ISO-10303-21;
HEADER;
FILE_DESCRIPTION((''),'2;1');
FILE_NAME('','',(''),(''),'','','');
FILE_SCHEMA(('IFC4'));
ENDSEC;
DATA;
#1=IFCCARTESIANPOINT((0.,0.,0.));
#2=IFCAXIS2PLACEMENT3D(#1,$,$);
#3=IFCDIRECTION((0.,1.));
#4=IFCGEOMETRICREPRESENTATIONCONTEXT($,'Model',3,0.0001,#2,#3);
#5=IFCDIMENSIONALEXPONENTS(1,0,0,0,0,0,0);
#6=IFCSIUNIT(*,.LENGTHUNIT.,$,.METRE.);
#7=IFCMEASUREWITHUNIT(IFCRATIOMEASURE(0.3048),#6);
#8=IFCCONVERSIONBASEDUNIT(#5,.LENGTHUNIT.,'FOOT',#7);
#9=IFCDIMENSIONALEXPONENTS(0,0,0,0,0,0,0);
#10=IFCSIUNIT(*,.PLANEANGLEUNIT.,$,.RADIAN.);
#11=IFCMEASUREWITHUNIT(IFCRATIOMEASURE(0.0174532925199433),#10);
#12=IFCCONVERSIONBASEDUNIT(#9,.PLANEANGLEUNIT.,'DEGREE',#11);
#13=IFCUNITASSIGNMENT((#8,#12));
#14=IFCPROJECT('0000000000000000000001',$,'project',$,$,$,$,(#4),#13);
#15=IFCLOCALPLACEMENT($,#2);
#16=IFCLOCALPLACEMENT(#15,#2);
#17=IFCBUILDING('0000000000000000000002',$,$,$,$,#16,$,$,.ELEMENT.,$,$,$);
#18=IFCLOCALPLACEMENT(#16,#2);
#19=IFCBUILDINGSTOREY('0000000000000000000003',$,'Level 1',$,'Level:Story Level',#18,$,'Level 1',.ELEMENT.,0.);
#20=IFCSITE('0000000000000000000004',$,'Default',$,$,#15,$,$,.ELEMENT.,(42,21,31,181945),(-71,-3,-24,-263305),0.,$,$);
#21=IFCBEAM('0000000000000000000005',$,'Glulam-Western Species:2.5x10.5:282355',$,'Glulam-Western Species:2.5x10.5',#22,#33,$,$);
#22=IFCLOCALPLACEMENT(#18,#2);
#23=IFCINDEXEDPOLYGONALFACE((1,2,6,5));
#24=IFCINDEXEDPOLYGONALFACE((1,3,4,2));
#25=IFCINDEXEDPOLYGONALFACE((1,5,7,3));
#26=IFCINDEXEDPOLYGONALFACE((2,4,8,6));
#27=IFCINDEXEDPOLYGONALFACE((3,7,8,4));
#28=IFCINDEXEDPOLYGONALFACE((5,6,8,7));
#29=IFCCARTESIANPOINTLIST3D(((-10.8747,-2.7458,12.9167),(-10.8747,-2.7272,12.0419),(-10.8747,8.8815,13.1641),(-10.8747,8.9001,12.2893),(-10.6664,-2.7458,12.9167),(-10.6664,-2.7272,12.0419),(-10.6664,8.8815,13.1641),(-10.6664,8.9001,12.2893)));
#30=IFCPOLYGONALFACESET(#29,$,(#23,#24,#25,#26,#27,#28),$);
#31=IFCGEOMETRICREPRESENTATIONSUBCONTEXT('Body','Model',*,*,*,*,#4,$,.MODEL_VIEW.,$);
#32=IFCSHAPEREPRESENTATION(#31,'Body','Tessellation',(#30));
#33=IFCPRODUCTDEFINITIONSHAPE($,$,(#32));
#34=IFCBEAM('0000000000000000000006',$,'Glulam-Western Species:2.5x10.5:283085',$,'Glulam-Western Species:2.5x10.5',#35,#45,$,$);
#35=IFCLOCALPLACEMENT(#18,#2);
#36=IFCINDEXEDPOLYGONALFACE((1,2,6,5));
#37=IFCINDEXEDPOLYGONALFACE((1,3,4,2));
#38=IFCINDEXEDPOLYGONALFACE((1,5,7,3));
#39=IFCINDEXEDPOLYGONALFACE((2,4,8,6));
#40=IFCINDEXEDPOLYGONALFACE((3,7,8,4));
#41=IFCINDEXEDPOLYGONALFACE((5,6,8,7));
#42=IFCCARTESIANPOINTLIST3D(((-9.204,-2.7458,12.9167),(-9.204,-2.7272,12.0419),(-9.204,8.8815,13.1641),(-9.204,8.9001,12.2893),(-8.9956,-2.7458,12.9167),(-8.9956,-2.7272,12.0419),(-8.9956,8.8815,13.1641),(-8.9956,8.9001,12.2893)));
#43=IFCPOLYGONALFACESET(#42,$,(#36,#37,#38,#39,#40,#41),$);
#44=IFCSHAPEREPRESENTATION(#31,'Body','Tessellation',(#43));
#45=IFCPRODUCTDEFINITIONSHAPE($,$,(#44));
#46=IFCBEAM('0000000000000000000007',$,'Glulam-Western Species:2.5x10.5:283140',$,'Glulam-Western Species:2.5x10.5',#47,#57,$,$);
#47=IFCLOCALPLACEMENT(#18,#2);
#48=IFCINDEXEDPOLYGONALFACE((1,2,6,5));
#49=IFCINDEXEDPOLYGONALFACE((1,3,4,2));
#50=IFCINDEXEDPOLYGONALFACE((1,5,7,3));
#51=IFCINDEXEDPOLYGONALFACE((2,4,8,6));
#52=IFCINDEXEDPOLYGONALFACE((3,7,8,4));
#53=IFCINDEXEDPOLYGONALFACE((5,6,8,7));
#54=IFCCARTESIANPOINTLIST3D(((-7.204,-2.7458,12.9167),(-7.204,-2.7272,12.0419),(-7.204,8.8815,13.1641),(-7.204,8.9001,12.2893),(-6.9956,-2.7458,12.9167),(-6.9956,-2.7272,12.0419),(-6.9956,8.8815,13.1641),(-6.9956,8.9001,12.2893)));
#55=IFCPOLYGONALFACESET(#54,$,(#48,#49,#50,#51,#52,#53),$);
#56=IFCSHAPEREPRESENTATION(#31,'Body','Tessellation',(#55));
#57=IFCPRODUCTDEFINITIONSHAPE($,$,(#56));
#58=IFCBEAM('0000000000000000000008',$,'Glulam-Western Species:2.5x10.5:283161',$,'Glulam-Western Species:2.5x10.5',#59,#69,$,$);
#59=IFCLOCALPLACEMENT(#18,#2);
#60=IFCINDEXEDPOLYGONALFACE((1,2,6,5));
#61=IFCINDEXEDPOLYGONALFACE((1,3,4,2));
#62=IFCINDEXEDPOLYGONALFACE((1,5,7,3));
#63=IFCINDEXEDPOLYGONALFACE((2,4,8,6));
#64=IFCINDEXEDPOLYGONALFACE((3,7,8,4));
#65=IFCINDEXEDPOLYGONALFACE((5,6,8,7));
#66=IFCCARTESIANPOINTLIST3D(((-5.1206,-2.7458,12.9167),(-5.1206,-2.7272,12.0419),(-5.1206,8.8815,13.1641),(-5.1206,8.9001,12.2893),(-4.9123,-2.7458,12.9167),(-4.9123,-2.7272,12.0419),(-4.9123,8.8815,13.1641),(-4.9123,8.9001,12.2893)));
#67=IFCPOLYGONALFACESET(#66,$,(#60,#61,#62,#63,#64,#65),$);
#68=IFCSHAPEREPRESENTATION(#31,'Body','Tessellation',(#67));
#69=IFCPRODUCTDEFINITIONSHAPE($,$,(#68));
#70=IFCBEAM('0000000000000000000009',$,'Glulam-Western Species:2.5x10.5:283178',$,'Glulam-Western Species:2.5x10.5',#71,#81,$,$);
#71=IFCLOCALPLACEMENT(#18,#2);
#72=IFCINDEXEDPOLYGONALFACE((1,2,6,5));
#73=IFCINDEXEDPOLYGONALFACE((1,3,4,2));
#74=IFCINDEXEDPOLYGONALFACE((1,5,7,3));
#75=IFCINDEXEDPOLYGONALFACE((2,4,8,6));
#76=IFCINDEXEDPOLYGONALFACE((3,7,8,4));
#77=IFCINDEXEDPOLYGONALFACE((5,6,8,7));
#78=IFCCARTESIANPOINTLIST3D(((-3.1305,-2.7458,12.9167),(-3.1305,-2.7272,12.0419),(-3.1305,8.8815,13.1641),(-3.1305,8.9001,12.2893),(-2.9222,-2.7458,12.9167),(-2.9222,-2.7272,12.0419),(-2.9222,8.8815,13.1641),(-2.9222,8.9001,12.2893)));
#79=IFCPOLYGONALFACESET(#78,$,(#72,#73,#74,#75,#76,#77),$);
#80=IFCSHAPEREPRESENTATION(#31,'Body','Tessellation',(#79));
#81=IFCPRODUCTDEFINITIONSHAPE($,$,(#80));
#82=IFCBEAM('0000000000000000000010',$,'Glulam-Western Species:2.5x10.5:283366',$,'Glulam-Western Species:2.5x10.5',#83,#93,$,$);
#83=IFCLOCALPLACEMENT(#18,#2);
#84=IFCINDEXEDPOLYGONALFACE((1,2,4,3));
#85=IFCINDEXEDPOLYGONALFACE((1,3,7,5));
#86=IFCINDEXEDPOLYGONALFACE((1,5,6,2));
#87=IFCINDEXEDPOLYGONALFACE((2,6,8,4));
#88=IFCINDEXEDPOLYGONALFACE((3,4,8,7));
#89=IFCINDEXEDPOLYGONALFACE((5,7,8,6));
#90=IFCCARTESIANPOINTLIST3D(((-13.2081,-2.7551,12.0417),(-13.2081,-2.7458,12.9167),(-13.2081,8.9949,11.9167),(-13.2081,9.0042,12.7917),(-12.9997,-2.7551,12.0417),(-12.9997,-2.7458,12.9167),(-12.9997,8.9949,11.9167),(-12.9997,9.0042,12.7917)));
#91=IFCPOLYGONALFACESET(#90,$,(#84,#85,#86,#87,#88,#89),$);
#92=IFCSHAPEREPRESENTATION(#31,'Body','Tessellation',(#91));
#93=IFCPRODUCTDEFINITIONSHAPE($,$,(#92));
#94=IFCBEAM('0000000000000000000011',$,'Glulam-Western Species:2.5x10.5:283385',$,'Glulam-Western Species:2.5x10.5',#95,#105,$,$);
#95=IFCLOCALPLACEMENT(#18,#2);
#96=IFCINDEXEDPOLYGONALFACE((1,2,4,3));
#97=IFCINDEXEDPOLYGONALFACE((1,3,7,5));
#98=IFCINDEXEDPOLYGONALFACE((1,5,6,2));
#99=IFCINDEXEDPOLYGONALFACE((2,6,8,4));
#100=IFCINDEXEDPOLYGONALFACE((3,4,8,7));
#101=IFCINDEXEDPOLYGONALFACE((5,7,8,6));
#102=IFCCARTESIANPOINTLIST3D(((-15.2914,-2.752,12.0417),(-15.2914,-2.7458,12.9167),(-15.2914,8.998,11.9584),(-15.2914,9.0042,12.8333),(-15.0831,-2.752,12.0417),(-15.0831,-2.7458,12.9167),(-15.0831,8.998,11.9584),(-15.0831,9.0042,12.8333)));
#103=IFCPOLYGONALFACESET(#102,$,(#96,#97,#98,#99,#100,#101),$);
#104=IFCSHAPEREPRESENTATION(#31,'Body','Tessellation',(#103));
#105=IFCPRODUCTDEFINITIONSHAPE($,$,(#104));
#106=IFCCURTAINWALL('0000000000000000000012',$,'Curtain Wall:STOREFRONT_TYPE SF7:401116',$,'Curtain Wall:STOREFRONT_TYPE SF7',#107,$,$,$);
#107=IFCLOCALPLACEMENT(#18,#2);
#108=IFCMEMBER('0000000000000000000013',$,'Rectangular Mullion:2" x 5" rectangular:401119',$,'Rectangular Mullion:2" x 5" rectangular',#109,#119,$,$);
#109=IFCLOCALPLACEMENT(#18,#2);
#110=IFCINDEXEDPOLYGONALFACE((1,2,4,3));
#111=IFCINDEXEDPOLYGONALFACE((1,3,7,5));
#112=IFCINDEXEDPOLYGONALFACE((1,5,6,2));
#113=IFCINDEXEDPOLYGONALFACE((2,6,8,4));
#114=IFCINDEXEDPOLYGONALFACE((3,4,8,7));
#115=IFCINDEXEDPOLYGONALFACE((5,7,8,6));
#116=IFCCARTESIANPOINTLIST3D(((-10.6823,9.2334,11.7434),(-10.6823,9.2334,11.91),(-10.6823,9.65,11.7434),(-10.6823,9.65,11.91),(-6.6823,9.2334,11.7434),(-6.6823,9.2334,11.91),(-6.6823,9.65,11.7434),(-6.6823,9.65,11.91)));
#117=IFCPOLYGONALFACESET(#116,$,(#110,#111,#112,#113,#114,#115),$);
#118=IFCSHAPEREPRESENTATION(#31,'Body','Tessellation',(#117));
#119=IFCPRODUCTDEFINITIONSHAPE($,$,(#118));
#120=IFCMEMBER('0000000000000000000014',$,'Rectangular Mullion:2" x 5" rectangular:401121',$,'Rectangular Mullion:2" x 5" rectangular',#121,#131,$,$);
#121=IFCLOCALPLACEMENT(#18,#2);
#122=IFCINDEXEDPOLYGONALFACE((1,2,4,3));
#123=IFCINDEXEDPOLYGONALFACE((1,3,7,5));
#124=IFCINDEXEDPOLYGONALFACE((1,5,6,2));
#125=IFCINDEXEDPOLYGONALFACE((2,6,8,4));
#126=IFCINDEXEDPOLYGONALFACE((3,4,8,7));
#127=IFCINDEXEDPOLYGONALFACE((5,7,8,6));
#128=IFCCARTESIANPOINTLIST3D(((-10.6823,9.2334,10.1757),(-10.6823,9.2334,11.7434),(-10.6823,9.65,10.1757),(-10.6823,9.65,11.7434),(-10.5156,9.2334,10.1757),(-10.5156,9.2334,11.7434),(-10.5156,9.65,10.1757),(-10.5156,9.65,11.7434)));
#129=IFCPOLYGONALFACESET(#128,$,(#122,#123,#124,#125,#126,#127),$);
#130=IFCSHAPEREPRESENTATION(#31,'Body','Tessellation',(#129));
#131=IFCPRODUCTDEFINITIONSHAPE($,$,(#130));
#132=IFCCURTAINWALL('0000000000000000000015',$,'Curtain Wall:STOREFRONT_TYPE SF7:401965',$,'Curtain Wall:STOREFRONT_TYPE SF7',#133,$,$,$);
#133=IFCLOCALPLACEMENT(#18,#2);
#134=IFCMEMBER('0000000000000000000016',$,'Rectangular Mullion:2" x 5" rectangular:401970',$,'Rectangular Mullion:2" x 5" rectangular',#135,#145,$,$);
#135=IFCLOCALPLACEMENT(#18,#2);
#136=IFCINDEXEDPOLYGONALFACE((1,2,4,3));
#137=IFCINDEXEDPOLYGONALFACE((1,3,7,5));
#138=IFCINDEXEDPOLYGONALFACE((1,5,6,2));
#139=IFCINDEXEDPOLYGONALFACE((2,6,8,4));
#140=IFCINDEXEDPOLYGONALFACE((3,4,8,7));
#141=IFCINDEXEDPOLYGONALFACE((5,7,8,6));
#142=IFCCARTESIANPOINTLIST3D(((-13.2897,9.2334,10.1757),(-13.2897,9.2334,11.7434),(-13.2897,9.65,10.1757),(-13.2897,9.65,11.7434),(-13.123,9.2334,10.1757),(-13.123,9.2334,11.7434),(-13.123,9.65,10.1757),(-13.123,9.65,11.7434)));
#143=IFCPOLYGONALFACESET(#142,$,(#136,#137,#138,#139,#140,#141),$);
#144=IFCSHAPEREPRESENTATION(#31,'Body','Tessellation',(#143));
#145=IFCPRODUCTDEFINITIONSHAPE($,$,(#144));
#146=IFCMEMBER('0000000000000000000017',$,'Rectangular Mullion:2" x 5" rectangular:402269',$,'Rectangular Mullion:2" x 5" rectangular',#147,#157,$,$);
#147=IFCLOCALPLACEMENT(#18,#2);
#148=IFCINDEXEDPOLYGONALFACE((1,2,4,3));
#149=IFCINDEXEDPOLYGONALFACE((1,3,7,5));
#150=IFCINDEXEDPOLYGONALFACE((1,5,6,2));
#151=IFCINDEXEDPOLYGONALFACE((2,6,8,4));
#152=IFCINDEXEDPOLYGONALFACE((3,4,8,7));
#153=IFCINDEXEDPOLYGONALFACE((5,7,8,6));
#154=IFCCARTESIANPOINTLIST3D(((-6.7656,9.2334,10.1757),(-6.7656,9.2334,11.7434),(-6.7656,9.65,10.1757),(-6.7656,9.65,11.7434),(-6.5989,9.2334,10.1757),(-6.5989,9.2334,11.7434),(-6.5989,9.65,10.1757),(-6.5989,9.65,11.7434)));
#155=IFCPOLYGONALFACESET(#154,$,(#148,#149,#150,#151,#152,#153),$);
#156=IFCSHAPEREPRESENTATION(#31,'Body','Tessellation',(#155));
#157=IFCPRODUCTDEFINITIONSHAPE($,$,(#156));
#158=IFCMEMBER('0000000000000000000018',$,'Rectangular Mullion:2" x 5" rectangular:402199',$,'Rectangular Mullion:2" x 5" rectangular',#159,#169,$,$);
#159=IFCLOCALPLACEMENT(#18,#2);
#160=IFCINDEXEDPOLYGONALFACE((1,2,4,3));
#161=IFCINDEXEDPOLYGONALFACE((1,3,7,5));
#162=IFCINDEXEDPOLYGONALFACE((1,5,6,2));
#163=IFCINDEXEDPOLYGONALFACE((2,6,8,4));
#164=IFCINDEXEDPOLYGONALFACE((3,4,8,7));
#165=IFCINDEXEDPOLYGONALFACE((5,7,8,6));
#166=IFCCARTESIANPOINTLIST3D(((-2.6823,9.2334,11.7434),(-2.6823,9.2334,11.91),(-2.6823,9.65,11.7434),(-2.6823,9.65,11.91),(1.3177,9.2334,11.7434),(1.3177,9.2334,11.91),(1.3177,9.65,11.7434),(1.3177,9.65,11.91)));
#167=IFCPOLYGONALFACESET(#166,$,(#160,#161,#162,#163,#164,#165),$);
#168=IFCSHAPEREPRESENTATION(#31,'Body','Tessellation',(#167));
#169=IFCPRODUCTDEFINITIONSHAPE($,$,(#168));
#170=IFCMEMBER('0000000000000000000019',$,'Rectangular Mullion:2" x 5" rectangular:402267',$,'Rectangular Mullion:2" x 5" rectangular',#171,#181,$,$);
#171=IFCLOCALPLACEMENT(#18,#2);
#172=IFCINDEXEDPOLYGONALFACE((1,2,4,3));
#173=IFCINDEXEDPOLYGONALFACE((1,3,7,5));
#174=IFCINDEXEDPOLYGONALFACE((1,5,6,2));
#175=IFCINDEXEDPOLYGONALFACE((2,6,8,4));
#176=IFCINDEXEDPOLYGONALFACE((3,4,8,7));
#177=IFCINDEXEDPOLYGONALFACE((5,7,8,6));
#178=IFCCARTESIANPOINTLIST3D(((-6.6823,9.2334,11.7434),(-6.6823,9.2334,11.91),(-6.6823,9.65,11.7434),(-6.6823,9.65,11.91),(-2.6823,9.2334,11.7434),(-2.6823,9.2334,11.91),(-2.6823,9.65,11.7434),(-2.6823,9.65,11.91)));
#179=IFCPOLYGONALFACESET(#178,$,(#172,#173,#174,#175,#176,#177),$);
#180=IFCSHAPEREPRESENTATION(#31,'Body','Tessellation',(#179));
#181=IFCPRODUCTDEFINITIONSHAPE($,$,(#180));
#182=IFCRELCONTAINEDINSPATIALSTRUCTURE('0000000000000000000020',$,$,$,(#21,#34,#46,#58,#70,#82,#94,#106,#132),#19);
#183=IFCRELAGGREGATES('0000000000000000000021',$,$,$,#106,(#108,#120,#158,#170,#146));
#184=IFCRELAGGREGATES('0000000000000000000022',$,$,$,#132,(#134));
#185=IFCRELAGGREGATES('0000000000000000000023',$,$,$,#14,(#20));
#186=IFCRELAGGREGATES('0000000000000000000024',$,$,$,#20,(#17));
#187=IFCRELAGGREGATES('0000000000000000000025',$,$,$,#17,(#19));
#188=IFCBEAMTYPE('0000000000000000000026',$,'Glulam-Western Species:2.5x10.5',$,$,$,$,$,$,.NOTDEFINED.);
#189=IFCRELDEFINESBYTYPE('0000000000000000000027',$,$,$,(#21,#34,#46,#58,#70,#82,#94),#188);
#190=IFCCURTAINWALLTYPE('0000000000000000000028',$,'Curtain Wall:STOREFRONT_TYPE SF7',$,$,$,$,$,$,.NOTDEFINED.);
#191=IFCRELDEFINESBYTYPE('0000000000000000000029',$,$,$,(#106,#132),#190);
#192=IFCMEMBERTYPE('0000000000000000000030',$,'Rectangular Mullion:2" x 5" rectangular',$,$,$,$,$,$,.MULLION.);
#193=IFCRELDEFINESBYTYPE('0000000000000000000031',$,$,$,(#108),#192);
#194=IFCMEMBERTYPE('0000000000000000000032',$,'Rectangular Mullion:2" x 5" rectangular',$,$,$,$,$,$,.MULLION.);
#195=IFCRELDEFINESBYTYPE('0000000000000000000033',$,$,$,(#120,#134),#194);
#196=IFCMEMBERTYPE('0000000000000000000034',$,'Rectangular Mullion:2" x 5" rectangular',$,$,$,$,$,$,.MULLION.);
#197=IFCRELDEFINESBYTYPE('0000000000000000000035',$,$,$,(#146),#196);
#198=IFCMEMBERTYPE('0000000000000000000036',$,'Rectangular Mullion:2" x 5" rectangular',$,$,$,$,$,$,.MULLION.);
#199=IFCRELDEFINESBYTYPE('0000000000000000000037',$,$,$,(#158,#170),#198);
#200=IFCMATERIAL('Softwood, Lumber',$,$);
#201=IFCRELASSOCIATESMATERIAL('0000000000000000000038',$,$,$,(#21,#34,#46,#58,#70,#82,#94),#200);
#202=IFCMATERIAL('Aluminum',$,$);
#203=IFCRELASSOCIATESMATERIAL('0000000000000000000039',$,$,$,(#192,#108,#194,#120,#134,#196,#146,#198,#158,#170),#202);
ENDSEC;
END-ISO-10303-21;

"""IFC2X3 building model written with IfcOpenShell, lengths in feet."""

from ifc_helpers import new_model, entity, si_unit, converted_unit, direction, frame, frame_2d, origin, origin_2d_with_axis, place, context, subcontext, project, spatial, rectangle, extrude, source, transform, mapped, material, type_object, type_shapes, element, aggregate, save


model = new_model("IFC2X3")

# Units and contexts
model_context = context("Model", 3, precision=0.0001, world=origin(), true_north=direction((0.0, 1.0)))
body_context = subcontext(model_context, "Body", "Model", "MODEL_VIEW")
ifc_project = project(units=[converted_unit("LENGTHUNIT", "FOOT", entity("IfcRatioMeasure", 0.3048), si_unit("LENGTHUNIT", "METRE"), dimensions=[1, 0, 0, 0, 0, 0, 0]), converted_unit("PLANEANGLEUNIT", "DEGREE", entity("IfcRatioMeasure", 0.0174532925199433), si_unit("PLANEANGLEUNIT", "RADIAN"), dimensions=[0, 0, 0, 0, 0, 0, 0])], contexts=[model_context])

# Site, building, storey
site_placement = place(None, origin())
site = spatial("IfcSite", under=ifc_project, at=site_placement, Name="Default", CompositionType="ELEMENT", RefLatitude=(42, 21, 31, 181945), RefLongitude=(-71, -3, -24, -263305), RefElevation=0.0)
building_placement = place(site_placement, origin())
building = spatial("IfcBuilding", under=site, at=building_placement, CompositionType="ELEMENT")
storey_placement = place(building_placement, origin())
storey = spatial("IfcBuildingStorey", under=building, at=storey_placement, Name="Level 1", ObjectType="Level:Story Level", LongName="Level 1", CompositionType="ELEMENT", Elevation=0.0)

# Beams
ifc_material_1 = material(Name="Softwood, Lumber")
beam_type = type_object("IfcBeamType", Name="Glulam-Western Species:2.5x10.5", PredefinedType="NOTDEFINED")
beam_1_placement = place(storey_placement, frame((-10.7706, 9.0042, 13.1667), z_axis=(0.0, -0.021272, 0.999774), x_axis=(0.0, -0.999774, -0.021272)))
element("IfcBeam", 1, at=beam_1_placement, inside=storey, type_object=beam_type, material=ifc_material_1, Name="Glulam-Western Species:2.5x10.5:282355", ObjectType="Glulam-Western Species:2.5x10.5", context=body_context, shape_type="SweptSolid", body=[
    extrude(rectangle(XDim=0.875, YDim=0.2083, at=origin_2d_with_axis()), frame((0.1228, 0.0, -0.4375), z_axis=(1.0, 0.0, 0.0), x_axis=(0.0, 0.0, -1.0)), (0.0, 0.0, 1.0), 11.6299),
])
beam_2_placement = place(storey_placement, frame((-9.0998, 9.0042, 13.1667), z_axis=(0.0, -0.021272, 0.999774), x_axis=(0.0, -0.999774, -0.021272)))
element("IfcBeam", 2, at=beam_2_placement, inside=storey, type_object=beam_type, material=ifc_material_1, Name="Glulam-Western Species:2.5x10.5:283085", ObjectType="Glulam-Western Species:2.5x10.5", context=body_context, shape_type="SweptSolid", body=[
    extrude(rectangle(XDim=0.875, YDim=0.2083, at=origin_2d_with_axis()), frame((0.1228, 0.0, -0.4375), z_axis=(1.0, 0.0, 0.0), x_axis=(0.0, 0.0, -1.0)), (0.0, 0.0, 1.0), 11.6299),
])
beam_3_placement = place(storey_placement, frame((-7.0998, 9.0042, 13.1667), z_axis=(0.0, -0.021272, 0.999774), x_axis=(0.0, -0.999774, -0.021272)))
element("IfcBeam", 3, at=beam_3_placement, inside=storey, type_object=beam_type, material=ifc_material_1, Name="Glulam-Western Species:2.5x10.5:283140", ObjectType="Glulam-Western Species:2.5x10.5", context=body_context, shape_type="SweptSolid", body=[
    extrude(rectangle(XDim=0.875, YDim=0.2083, at=frame_2d((0.0, 0.0), x_axis=(1.0, 0.0))), frame((0.1228, 0.0, -0.4375), z_axis=(1.0, 0.0, 0.0), x_axis=(0.0, 0.0, -1.0)), (0.0, 0.0, 1.0), 11.6299),
])
beam_4_placement = place(storey_placement, frame((-5.0165, 9.0042, 13.1667), z_axis=(0.0, -0.021272, 0.999774), x_axis=(0.0, -0.999774, -0.021272)))
element("IfcBeam", 4, at=beam_4_placement, inside=storey, type_object=beam_type, material=ifc_material_1, Name="Glulam-Western Species:2.5x10.5:283161", ObjectType="Glulam-Western Species:2.5x10.5", context=body_context, shape_type="SweptSolid", body=[
    extrude(rectangle(XDim=0.875, YDim=0.2083, at=origin_2d_with_axis()), frame((0.1228, 0.0, -0.4375), z_axis=(1.0, 0.0, 0.0), x_axis=(0.0, 0.0, -1.0)), (0.0, 0.0, 1.0), 11.6299),
])
beam_5_placement = place(storey_placement, frame((-3.0263, 9.0042, 13.1667), z_axis=(0.0, -0.021272, 0.999774), x_axis=(0.0, -0.999774, -0.021272)))
element("IfcBeam", 5, at=beam_5_placement, inside=storey, type_object=beam_type, material=ifc_material_1, Name="Glulam-Western Species:2.5x10.5:283178", ObjectType="Glulam-Western Species:2.5x10.5", context=body_context, shape_type="SweptSolid", body=[
    extrude(rectangle(XDim=0.875, YDim=0.2083, at=frame_2d((0.0, 0.0), x_axis=(1.0, 0.0))), frame((0.1228, 0.0, -0.4375), z_axis=(1.0, 0.0, 0.0), x_axis=(0.0, 0.0, -1.0)), (0.0, 0.0, 1.0), 11.6299),
])
beam_6_placement = place(storey_placement, frame((-13.1039, 9.0042, 12.7917), z_axis=(0.0, 0.010638, 0.999943), x_axis=(0.0, -0.999943, 0.010638)))
element("IfcBeam", 6, at=beam_6_placement, inside=storey, type_object=beam_type, material=ifc_material_1, Name="Glulam-Western Species:2.5x10.5:283366", ObjectType="Glulam-Western Species:2.5x10.5", context=body_context, shape_type="SweptSolid", body=[
    extrude(rectangle(XDim=0.875, YDim=0.2083, at=frame_2d((0.0, 0.0), x_axis=(1.0, 0.0))), frame((0.0, 0.0, -0.4375), z_axis=(1.0, 0.0, 0.0), x_axis=(0.0, 0.0, -1.0)), (0.0, 0.0, 1.0), 11.7507),
])
beam_7_placement = place(storey_placement, frame((-15.1872, 9.0042, 12.8333), z_axis=(0.0, 0.007092, 0.999975), x_axis=(0.0, -0.999975, 0.007092)))
element("IfcBeam", 7, at=beam_7_placement, inside=storey, type_object=beam_type, material=ifc_material_1, Name="Glulam-Western Species:2.5x10.5:283385", ObjectType="Glulam-Western Species:2.5x10.5", context=body_context, shape_type="SweptSolid", body=[
    extrude(rectangle(XDim=0.875, YDim=0.2083, at=origin_2d_with_axis()), frame((0.0, 0.0, -0.4375), z_axis=(1.0, 0.0, 0.0), x_axis=(0.0, 0.0, -1.0)), (0.0, 0.0, 1.0), 11.7503),
])

# Curtain wall, members
curtain_wall_type = type_object("IfcCurtainWallType", Name="Curtain Wall:STOREFRONT_TYPE SF7", PredefinedType="NOTDEFINED")
curtain_wall_1_placement = place(storey_placement, origin())
curtain_wall_1 = element("IfcCurtainWall", 8, at=curtain_wall_1_placement, inside=storey, type_object=curtain_wall_type, Name="Curtain Wall:STOREFRONT_TYPE SF7:401116", ObjectType="Curtain Wall:STOREFRONT_TYPE SF7")
ifc_material_2 = material(Name="Aluminum")
member_type_1 = type_object("IfcMemberType", Name="Rectangular Mullion:2\" x 5\" rectangular", PredefinedType="MULLION", material=ifc_material_2)
shared_shape_1 = source(origin(), body_context, "Body", "SweptSolid", [
    extrude(rectangle(XDim=0.4167, YDim=0.1667, at=origin_2d_with_axis()), frame((-0.0833, 0.0, -4.0), z_axis=(0.0, 0.0, 1.0), x_axis=(0.0, -1.0, 0.0)), (0.0, 0.0, 1.0), 4.0),
])
type_shapes(member_type_1, [shared_shape_1])
member_1_placement = place(curtain_wall_1_placement, frame((-10.6823, 9.4417, 11.91), z_axis=(-1.0, 0.0, 0.0), x_axis=(0.0, 0.0, 1.0)))
member_1 = element("IfcMember", 9, at=member_1_placement, type_object=member_type_1, material=ifc_material_2, Name="Rectangular Mullion:2\" x 5\" rectangular:401119", ObjectType="Rectangular Mullion:2\" x 5\" rectangular", context=body_context, shape_type="MappedRepresentation", body=[
    mapped(shared_shape_1, transform((0.0, 0.0, 0.0), scale=1.0)),
])
member_type_2 = type_object("IfcMemberType", Name="Rectangular Mullion:2\" x 5\" rectangular", PredefinedType="MULLION", material=ifc_material_2)
shared_shape_2 = source(origin(), body_context, "Body", "SweptSolid", [
    extrude(rectangle(XDim=0.4167, YDim=0.1667, at=origin_2d_with_axis()), frame((-0.0833, 0.0, -1.5677), z_axis=(0.0, 0.0, 1.0), x_axis=(0.0, -1.0, 0.0)), (0.0, 0.0, 1.0), 1.5677),
])
type_shapes(member_type_2, [shared_shape_2])
member_2_placement = place(curtain_wall_1_placement, frame((-10.6823, 9.4417, 10.1757), z_axis=(0.0, 0.0, -1.0), x_axis=(-1.0, 0.0, 0.0)))
member_2 = element("IfcMember", 10, at=member_2_placement, type_object=member_type_2, material=ifc_material_2, Name="Rectangular Mullion:2\" x 5\" rectangular:401121", ObjectType="Rectangular Mullion:2\" x 5\" rectangular", context=body_context, shape_type="MappedRepresentation", body=[
    mapped(shared_shape_2, transform((0.0, 0.0, 0.0), scale=1.0)),
])

# Curtain wall, member
curtain_wall_2_placement = place(storey_placement, origin())
curtain_wall_2 = element("IfcCurtainWall", 11, at=curtain_wall_2_placement, inside=storey, type_object=curtain_wall_type, Name="Curtain Wall:STOREFRONT_TYPE SF7:401965", ObjectType="Curtain Wall:STOREFRONT_TYPE SF7")
member_3_placement = place(curtain_wall_2_placement, frame((-13.123, 9.4417, 10.1757), z_axis=(0.0, 0.0, -1.0), x_axis=(1.0, 0.0, 0.0)))
member_3 = element("IfcMember", 12, at=member_3_placement, type_object=member_type_2, material=ifc_material_2, Name="Rectangular Mullion:2\" x 5\" rectangular:401970", ObjectType="Rectangular Mullion:2\" x 5\" rectangular", context=body_context, shape_type="MappedRepresentation", body=[
    mapped(shared_shape_2, transform((0.0, 0.0, 0.0), scale=1.0)),
])

# Members
member_type_3 = type_object("IfcMemberType", Name="Rectangular Mullion:2\" x 5\" rectangular", PredefinedType="MULLION", material=ifc_material_2)
shared_shape_3 = source(origin(), body_context, "Body", "SweptSolid", [
    extrude(rectangle(XDim=0.4167, YDim=0.1667, at=origin_2d_with_axis()), frame((0.0, 0.0, -1.5677), z_axis=(0.0, 0.0, 1.0), x_axis=(0.0, -1.0, 0.0)), (0.0, 0.0, 1.0), 1.5677),
])
type_shapes(member_type_3, [shared_shape_3])
member_4_placement = place(curtain_wall_1_placement, frame((-6.6823, 9.4417, 10.1757), z_axis=(0.0, 0.0, -1.0), x_axis=(-1.0, 0.0, 0.0)))
member_4 = element("IfcMember", 13, at=member_4_placement, type_object=member_type_3, material=ifc_material_2, Name="Rectangular Mullion:2\" x 5\" rectangular:402269", ObjectType="Rectangular Mullion:2\" x 5\" rectangular", context=body_context, shape_type="MappedRepresentation", body=[
    mapped(shared_shape_3, transform((0.0, 0.0, 0.0), scale=1.0)),
])
member_type_4 = type_object("IfcMemberType", Name="Rectangular Mullion:2\" x 5\" rectangular", PredefinedType="MULLION", material=ifc_material_2)
shared_shape_4 = source(origin(), body_context, "Body", "SweptSolid", [
    extrude(rectangle(XDim=0.4167, YDim=0.1667, at=origin_2d_with_axis()), frame((-0.0833, 0.0, -4.0), z_axis=(0.0, 0.0, 1.0), x_axis=(0.0, -1.0, 0.0)), (0.0, 0.0, 1.0), 4.0),
])
type_shapes(member_type_4, [shared_shape_4])
member_5_placement = place(curtain_wall_1_placement, frame((-2.6823, 9.4417, 11.91), z_axis=(-1.0, 0.0, 0.0), x_axis=(0.0, 0.0, 1.0)))
member_5 = element("IfcMember", 14, at=member_5_placement, type_object=member_type_4, material=ifc_material_2, Name="Rectangular Mullion:2\" x 5\" rectangular:402199", ObjectType="Rectangular Mullion:2\" x 5\" rectangular", context=body_context, shape_type="MappedRepresentation", body=[
    mapped(shared_shape_4, transform((0.0, 0.0, 0.0), scale=1.0)),
])
member_6_placement = place(curtain_wall_1_placement, frame((-6.6823, 9.4417, 11.91), z_axis=(-1.0, 0.0, 0.0), x_axis=(0.0, 0.0, 1.0)))
member_6 = element("IfcMember", 15, at=member_6_placement, type_object=member_type_4, material=ifc_material_2, Name="Rectangular Mullion:2\" x 5\" rectangular:402267", ObjectType="Rectangular Mullion:2\" x 5\" rectangular", context=body_context, shape_type="MappedRepresentation", body=[
    mapped(shared_shape_4, transform((0.0, 0.0, 0.0), scale=1.0)),
])

aggregate(curtain_wall_1, [member_1, member_2, member_5, member_6, member_4])
aggregate(curtain_wall_2, [member_3])

save(model, "model.ifc")
